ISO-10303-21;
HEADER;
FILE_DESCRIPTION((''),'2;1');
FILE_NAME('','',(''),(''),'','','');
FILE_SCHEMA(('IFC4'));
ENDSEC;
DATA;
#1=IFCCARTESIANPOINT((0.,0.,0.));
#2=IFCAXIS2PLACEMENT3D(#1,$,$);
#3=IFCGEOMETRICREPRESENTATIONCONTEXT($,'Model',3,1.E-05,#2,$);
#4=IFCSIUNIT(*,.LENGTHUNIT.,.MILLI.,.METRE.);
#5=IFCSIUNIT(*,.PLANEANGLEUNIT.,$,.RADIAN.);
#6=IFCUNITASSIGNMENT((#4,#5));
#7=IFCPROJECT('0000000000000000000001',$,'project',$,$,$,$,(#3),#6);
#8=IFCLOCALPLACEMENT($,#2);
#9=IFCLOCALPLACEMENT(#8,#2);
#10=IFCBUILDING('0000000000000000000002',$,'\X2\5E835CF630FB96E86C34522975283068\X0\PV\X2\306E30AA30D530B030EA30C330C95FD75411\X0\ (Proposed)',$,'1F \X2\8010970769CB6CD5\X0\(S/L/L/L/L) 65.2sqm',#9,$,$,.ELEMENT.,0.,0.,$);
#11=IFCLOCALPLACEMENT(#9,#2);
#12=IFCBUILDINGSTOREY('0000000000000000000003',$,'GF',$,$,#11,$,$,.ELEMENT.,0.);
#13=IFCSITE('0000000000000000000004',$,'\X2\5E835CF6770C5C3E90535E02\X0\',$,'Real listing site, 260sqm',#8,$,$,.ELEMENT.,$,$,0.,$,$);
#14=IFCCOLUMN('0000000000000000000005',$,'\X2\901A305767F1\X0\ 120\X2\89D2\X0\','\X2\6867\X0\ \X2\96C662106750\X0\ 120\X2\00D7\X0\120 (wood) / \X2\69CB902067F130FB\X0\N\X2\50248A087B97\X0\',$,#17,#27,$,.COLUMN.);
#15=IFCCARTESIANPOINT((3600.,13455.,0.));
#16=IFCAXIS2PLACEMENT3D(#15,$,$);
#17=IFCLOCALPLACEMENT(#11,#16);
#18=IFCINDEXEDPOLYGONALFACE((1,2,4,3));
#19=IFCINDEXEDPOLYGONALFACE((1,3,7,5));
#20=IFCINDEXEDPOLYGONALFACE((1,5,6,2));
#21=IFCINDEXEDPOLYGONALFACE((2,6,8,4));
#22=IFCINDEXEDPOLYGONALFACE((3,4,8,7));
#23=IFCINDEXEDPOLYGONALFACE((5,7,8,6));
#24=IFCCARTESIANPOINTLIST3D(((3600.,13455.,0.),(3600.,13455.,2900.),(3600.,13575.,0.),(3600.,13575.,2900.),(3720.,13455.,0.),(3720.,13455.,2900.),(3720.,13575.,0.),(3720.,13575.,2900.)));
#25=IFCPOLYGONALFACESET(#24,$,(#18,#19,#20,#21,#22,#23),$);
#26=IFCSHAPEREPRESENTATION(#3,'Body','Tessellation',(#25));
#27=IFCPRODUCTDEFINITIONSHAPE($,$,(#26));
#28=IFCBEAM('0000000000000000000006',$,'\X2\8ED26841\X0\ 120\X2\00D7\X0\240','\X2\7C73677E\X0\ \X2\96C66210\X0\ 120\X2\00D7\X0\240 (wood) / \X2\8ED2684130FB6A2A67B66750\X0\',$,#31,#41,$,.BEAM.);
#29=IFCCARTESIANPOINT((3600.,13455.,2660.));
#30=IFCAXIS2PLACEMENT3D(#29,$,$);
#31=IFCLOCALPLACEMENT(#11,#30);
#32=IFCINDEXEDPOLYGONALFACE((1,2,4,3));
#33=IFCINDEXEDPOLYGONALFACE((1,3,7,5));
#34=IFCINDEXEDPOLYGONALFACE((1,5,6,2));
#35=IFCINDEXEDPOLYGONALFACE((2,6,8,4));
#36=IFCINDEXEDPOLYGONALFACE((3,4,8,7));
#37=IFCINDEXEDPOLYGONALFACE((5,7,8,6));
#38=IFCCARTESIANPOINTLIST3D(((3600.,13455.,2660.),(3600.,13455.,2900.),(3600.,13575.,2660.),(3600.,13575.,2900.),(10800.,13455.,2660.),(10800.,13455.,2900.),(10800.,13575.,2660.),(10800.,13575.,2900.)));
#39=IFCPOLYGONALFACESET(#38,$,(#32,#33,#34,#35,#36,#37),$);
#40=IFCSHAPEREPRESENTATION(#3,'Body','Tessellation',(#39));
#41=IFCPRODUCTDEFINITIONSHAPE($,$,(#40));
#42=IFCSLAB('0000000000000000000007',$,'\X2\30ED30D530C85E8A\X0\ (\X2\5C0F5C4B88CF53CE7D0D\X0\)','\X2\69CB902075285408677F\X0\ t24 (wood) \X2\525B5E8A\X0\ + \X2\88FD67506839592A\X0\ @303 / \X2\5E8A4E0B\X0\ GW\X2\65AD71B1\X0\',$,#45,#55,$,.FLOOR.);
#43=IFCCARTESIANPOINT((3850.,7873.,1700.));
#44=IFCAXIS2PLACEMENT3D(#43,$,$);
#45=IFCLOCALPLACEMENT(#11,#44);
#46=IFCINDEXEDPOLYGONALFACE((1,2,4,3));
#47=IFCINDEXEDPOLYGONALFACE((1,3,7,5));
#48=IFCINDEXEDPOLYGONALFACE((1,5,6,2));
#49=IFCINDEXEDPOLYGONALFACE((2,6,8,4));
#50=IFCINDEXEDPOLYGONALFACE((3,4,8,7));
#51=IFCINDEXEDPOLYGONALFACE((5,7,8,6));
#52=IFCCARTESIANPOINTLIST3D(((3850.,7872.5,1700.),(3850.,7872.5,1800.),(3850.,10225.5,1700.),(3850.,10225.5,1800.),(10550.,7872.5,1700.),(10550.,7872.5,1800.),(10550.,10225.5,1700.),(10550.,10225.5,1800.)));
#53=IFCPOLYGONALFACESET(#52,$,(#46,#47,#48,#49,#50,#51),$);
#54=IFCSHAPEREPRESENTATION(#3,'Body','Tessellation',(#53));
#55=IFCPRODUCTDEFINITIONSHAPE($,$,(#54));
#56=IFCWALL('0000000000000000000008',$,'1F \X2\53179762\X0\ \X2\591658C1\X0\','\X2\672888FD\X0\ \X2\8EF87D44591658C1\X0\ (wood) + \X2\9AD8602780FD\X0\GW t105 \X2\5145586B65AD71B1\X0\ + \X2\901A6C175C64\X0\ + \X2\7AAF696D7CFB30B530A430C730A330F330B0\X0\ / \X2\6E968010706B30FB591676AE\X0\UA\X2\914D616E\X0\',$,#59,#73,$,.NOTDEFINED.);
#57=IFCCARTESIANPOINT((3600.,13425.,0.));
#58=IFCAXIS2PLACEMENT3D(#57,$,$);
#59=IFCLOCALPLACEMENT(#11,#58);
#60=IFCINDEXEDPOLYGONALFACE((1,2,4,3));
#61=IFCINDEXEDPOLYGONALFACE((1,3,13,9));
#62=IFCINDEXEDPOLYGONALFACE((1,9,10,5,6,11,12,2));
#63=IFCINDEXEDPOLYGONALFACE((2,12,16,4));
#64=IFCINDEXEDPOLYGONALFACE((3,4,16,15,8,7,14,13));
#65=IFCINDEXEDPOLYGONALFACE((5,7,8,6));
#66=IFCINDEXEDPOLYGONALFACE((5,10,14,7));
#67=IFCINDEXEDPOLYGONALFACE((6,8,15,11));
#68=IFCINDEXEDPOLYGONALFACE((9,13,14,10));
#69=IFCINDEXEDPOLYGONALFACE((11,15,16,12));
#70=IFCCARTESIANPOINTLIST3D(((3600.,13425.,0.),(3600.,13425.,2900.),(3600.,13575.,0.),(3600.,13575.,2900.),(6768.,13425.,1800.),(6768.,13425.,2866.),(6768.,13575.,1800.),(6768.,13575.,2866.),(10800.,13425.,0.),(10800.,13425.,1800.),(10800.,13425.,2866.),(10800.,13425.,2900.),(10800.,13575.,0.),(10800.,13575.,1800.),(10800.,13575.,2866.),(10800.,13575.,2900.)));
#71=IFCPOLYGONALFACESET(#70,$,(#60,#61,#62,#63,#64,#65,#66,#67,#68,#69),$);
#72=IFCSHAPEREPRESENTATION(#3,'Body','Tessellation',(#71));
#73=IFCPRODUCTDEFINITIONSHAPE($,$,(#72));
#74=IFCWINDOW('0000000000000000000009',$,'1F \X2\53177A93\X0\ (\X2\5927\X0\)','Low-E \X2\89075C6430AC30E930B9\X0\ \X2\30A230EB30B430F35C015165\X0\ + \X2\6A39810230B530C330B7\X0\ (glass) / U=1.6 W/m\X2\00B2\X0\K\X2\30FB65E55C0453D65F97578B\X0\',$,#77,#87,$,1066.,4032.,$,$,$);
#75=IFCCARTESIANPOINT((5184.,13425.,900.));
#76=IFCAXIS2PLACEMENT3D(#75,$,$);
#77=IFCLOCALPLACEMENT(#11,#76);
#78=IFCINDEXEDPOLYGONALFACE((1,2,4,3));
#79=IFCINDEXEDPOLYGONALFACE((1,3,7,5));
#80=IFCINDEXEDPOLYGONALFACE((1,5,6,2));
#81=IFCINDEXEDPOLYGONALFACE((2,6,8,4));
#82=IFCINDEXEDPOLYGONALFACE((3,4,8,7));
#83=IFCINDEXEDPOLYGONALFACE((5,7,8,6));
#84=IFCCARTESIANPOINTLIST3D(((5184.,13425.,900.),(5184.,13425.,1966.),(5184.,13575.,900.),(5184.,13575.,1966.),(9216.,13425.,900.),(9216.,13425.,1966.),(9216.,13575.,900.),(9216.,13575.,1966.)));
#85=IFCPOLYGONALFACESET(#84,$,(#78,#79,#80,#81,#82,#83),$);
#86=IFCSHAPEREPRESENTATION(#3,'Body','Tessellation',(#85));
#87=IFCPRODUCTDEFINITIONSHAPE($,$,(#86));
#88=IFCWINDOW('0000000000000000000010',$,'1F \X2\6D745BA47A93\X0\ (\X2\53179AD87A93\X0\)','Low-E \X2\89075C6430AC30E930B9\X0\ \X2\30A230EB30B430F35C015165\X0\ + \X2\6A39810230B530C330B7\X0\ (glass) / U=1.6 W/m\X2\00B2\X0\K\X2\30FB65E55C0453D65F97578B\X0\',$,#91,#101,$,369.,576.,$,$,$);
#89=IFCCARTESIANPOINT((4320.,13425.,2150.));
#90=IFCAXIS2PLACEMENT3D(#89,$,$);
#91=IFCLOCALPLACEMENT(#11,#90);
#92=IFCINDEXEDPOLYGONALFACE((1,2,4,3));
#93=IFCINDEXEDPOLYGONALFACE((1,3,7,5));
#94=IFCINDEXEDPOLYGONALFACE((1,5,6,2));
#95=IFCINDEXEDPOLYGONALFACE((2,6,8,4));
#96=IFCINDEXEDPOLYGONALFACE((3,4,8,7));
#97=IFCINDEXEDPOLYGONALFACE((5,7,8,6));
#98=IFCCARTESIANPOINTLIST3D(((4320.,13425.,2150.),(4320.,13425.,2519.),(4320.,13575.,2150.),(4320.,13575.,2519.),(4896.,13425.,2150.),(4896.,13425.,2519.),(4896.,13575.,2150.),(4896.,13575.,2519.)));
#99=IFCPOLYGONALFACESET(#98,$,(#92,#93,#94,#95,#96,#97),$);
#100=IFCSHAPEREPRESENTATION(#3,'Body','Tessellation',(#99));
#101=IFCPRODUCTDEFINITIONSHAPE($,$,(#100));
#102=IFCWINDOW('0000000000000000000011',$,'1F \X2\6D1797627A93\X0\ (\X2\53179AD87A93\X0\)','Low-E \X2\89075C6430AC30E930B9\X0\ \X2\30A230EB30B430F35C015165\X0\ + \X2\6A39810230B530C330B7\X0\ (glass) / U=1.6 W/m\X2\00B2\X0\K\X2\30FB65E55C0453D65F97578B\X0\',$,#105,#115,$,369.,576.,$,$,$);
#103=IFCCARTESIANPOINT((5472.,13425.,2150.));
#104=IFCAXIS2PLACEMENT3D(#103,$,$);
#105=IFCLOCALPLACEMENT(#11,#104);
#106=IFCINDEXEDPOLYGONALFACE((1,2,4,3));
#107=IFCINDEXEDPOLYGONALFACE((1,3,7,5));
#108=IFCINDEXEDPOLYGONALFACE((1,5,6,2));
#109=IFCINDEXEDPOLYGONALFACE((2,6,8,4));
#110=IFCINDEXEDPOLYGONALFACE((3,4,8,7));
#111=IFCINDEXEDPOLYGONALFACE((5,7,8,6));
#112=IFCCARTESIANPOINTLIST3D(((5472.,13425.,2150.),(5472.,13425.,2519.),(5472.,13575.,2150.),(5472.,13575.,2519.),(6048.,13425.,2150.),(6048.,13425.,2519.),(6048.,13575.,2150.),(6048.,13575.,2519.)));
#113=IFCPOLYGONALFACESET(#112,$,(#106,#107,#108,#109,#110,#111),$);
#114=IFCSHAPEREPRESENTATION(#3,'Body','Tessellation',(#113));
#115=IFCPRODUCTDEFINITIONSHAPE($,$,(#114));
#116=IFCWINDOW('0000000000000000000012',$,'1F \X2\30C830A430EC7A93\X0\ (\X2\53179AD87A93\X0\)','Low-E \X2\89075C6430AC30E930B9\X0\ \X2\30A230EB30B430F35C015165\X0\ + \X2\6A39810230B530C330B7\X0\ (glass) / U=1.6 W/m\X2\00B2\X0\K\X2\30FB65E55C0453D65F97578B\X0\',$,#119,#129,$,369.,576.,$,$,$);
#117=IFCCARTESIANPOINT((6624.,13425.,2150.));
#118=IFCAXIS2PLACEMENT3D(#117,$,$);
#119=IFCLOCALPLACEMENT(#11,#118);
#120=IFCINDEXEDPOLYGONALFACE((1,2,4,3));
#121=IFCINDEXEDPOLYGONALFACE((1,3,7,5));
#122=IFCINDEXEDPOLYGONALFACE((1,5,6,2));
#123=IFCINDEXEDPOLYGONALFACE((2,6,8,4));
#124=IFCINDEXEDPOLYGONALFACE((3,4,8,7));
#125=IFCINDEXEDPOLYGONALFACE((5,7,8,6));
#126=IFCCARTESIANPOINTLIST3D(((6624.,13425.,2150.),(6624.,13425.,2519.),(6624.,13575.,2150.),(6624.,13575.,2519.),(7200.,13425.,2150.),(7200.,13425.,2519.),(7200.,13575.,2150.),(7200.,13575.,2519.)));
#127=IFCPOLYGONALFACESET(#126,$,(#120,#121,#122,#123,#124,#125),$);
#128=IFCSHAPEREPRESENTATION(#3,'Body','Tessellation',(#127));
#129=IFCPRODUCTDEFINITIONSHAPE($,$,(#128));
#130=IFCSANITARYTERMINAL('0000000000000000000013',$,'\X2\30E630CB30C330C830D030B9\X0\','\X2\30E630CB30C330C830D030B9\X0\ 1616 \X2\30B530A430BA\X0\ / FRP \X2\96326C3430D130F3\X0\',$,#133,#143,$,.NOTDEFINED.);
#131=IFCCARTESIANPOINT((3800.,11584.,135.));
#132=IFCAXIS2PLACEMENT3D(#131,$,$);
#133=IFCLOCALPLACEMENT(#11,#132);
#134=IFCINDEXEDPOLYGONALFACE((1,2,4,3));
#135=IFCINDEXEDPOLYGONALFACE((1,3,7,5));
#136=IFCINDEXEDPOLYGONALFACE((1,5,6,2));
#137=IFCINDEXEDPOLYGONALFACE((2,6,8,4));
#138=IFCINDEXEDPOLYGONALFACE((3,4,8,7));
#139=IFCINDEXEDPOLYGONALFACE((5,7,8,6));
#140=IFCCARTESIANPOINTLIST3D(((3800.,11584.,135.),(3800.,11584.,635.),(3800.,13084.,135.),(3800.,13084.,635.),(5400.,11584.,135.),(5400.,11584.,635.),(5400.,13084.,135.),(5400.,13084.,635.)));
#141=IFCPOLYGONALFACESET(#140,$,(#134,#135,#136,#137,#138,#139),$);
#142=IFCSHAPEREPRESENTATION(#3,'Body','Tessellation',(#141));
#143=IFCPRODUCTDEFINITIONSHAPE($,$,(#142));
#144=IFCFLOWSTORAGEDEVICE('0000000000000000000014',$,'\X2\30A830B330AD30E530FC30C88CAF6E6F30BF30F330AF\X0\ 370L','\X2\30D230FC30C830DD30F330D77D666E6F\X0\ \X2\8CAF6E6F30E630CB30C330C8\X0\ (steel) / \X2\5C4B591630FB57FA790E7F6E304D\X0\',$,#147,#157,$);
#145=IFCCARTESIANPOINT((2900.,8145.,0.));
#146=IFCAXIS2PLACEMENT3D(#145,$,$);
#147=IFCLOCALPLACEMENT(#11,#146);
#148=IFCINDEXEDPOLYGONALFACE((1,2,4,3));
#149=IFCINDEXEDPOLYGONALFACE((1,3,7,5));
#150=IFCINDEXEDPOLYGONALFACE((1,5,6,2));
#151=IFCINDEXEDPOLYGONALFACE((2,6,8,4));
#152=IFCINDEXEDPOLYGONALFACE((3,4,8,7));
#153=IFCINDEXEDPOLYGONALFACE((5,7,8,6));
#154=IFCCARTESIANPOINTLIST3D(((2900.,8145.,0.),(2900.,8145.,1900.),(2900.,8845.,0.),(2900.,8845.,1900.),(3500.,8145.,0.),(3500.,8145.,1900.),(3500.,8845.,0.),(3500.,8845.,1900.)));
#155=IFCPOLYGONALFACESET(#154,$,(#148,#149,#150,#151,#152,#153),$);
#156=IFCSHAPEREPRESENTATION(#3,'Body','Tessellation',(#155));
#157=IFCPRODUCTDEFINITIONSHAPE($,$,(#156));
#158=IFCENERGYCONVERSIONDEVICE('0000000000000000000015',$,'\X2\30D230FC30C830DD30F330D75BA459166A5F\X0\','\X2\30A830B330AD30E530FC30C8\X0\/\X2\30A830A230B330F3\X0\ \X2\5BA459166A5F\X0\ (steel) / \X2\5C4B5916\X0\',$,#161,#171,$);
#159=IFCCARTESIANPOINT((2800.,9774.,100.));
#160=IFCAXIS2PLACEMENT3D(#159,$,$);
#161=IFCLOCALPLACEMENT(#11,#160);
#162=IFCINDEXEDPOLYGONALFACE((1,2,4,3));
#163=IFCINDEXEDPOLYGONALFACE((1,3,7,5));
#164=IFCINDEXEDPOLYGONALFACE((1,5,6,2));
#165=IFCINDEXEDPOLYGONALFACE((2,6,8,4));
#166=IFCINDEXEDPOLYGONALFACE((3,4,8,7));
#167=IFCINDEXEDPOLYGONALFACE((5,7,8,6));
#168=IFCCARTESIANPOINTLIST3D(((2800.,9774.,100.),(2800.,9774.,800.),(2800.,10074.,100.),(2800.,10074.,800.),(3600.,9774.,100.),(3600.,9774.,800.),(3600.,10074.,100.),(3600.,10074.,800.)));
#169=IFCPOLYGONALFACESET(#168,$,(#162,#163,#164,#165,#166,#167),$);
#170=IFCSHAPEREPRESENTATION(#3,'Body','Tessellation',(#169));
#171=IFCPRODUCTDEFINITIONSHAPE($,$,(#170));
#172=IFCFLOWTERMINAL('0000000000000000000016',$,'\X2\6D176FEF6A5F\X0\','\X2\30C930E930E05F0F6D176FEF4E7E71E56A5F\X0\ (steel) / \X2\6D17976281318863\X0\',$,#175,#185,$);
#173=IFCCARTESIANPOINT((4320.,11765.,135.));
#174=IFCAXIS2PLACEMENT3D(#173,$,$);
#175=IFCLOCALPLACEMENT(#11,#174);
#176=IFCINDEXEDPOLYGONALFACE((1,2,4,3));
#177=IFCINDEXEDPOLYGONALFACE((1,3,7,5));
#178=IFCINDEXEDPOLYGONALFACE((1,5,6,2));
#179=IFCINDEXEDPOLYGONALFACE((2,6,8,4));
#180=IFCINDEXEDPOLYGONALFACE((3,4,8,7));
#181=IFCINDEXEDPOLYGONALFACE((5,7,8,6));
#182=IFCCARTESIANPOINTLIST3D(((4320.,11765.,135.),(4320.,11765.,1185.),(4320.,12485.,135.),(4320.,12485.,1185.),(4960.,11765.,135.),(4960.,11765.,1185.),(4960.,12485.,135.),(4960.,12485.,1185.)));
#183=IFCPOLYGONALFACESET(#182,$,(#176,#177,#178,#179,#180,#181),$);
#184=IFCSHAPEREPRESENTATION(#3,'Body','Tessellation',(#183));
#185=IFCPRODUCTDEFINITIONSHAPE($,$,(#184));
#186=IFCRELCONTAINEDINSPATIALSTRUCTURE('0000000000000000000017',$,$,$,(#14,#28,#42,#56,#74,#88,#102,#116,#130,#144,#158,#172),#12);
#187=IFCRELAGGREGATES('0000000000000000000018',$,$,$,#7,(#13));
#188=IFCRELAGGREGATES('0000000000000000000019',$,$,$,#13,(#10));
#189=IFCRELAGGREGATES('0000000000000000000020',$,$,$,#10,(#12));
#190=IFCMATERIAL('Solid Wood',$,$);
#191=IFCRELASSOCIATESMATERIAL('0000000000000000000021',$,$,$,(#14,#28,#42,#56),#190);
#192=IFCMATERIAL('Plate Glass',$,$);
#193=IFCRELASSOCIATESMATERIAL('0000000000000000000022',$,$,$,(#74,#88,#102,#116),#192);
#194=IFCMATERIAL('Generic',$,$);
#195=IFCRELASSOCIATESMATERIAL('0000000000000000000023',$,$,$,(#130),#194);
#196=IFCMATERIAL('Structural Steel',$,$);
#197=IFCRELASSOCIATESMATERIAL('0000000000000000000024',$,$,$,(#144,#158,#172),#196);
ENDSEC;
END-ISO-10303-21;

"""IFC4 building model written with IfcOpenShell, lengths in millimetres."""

from ifc_helpers import new_model, si_unit, frame, frame_2d, origin, place, context, project, spatial, rectangle, extrude, material, element, fill, save


model = new_model("IFC4")

# Units and contexts
model_context = context("Model", 3, precision=1e-05, world=origin())
ifc_project = project(units=[si_unit("LENGTHUNIT", "METRE", prefix="MILLI"), si_unit("PLANEANGLEUNIT", "RADIAN")], contexts=[model_context])

# Site, building, storey
site_placement = place(None, origin())
site = spatial("IfcSite", under=ifc_project, at=site_placement, Name="広島県尾道市", ObjectType="Real listing site, 260sqm", CompositionType="ELEMENT", RefElevation=0.0)
building_placement = place(site_placement, origin())
building = spatial("IfcBuilding", under=site, at=building_placement, Name="広島・雨水利用とPVのオフグリッド志向 (Proposed)", ObjectType="1F 耐震構法(S/L/L/L/L) 65.2sqm", CompositionType="ELEMENT", ElevationOfRefHeight=0.0, ElevationOfTerrain=0.0)
storey_placement = place(building_placement, origin())
storey = spatial("IfcBuildingStorey", under=building, at=storey_placement, Name="GF", CompositionType="ELEMENT", Elevation=0.0)

# Column
ifc_material_1 = material(Name="Solid Wood")
column_1_placement = place(storey_placement, frame((3600.0, 13455.0, 0.0)))
element("IfcColumn", 1, at=column_1_placement, inside=storey, material=ifc_material_1, Name="通し柱 120角", Description="桧 集成材 120×120 (wood) / 構造柱・N値計算", PredefinedType="COLUMN", context=model_context, shape_type="SweptSolid", body=[
    extrude(rectangle(XDim=120.0, YDim=120.0, at=frame_2d((60.0, 60.0))), frame((3600.0, 13455.0, 0.0)), (0.0, 0.0, 1.0), 2900.0),
])

# Beam
beam_1_placement = place(storey_placement, frame((3600.0, 13455.0, 2660.0)))
element("IfcBeam", 2, at=beam_1_placement, inside=storey, material=ifc_material_1, Name="軒桁 120×240", Description="米松 集成 120×240 (wood) / 軒桁・横架材", PredefinedType="BEAM", context=model_context, shape_type="SweptSolid", body=[
    extrude(rectangle(XDim=7200.0, YDim=120.0, at=frame_2d((3600.0, 60.0))), frame((3600.0, 13455.0, 2660.0)), (0.0, 0.0, 1.0), 240.0),
])

# Slab
slab_placement = place(storey_placement, frame((3850.0, 7873.0, 1700.0)))
element("IfcSlab", 3, at=slab_placement, inside=storey, material=ifc_material_1, Name="ロフト床 (小屋裏収納)", Description="構造用合板 t24 (wood) 剛床 + 製材根太 @303 / 床下 GW断熱", PredefinedType="FLOOR", context=model_context, shape_type="SweptSolid", body=[
    extrude(rectangle(XDim=6700.0, YDim=2353.0, at=frame_2d((3350.0, 1176.0))), frame((3850.0, 7873.0, 1700.0)), (0.0, 0.0, 1.0), 100.0),
])

# Wall, openings, windows
wall_1_placement = place(storey_placement, frame((3600.0, 13425.0, 0.0)))
wall_1 = element("IfcWall", 4, at=wall_1_placement, inside=storey, material=ifc_material_1, Name="1F 北面 外壁", Description="木製 軸組外壁 (wood) + 高性能GW t105 充填断熱 + 通気層 + 窯業系サイディング / 準耐火・外皮UA配慮", PredefinedType="NOTDEFINED", context=model_context, shape_type="SweptSolid", body=[
    extrude(rectangle(XDim=7200.0, YDim=150.0, at=frame_2d((3600.0, 75.0))), frame((3600.0, 13425.0, 0.0)), (0.0, 0.0, 1.0), 2900.0),
])
opening_1_placement = place(storey_placement, frame((5184.0, 13425.0, 900.0)))
opening_1 = element("IfcOpeningElement", 5, at=opening_1_placement, cuts=wall_1, PredefinedType="NOTDEFINED", context=model_context, shape_type="SweptSolid", body=[
    extrude(rectangle(XDim=4032.0, YDim=150.0, at=frame_2d((2016.0, 75.0))), frame((5184.0, 13425.0, 900.0)), (0.0, 0.0, 1.0), 1066.0),
])
opening_2_placement = place(storey_placement, frame((4320.0, 13425.0, 2150.0)))
opening_2 = element("IfcOpeningElement", 6, at=opening_2_placement, cuts=wall_1, PredefinedType="NOTDEFINED", context=model_context, shape_type="SweptSolid", body=[
    extrude(rectangle(XDim=576.0, YDim=150.0, at=frame_2d((288.0, 75.0))), frame((4320.0, 13425.0, 2150.0)), (0.0, 0.0, 1.0), 369.0),
])
opening_3_placement = place(storey_placement, frame((5472.0, 13425.0, 2150.0)))
opening_3 = element("IfcOpeningElement", 7, at=opening_3_placement, cuts=wall_1, PredefinedType="NOTDEFINED", context=model_context, shape_type="SweptSolid", body=[
    extrude(rectangle(XDim=576.0, YDim=150.0, at=frame_2d((288.0, 75.0))), frame((5472.0, 13425.0, 2150.0)), (0.0, 0.0, 1.0), 369.0),
])
opening_4_placement = place(storey_placement, frame((6624.0, 13425.0, 2150.0)))
opening_4 = element("IfcOpeningElement", 8, at=opening_4_placement, cuts=wall_1, PredefinedType="NOTDEFINED", context=model_context, shape_type="SweptSolid", body=[
    extrude(rectangle(XDim=576.0, YDim=150.0, at=frame_2d((288.0, 75.0))), frame((6624.0, 13425.0, 2150.0)), (0.0, 0.0, 1.0), 369.0),
])
ifc_material_2 = material(Name="Plate Glass")
window_1_placement = place(storey_placement, frame((5184.0, 13425.0, 900.0)))
window_1 = element("IfcWindow", 9, at=window_1_placement, inside=storey, material=ifc_material_2, Name="1F 北窓 (大)", Description="Low-E 複層ガラス アルゴン封入 + 樹脂サッシ (glass) / U=1.6 W/m²K・日射取得型", OverallHeight=1066.0, OverallWidth=4032.0, context=model_context, shape_type="SweptSolid", body=[
    extrude(rectangle(XDim=4032.0, YDim=150.0, at=frame_2d((2016.0, 75.0))), frame((5184.0, 13425.0, 900.0)), (0.0, 0.0, 1.0), 1066.0),
])
fill(opening_1, window_1)
window_2_placement = place(storey_placement, frame((4320.0, 13425.0, 2150.0)))
window_2 = element("IfcWindow", 10, at=window_2_placement, inside=storey, material=ifc_material_2, Name="1F 浴室窓 (北高窓)", Description="Low-E 複層ガラス アルゴン封入 + 樹脂サッシ (glass) / U=1.6 W/m²K・日射取得型", OverallHeight=369.0, OverallWidth=576.0, context=model_context, shape_type="SweptSolid", body=[
    extrude(rectangle(XDim=576.0, YDim=150.0, at=frame_2d((288.0, 75.0))), frame((4320.0, 13425.0, 2150.0)), (0.0, 0.0, 1.0), 369.0),
])
fill(opening_2, window_2)
window_3_placement = place(storey_placement, frame((5472.0, 13425.0, 2150.0)))
window_3 = element("IfcWindow", 11, at=window_3_placement, inside=storey, material=ifc_material_2, Name="1F 洗面窓 (北高窓)", Description="Low-E 複層ガラス アルゴン封入 + 樹脂サッシ (glass) / U=1.6 W/m²K・日射取得型", OverallHeight=369.0, OverallWidth=576.0, context=model_context, shape_type="SweptSolid", body=[
    extrude(rectangle(XDim=576.0, YDim=150.0, at=frame_2d((288.0, 75.0))), frame((5472.0, 13425.0, 2150.0)), (0.0, 0.0, 1.0), 369.0),
])
fill(opening_3, window_3)
window_4_placement = place(storey_placement, frame((6624.0, 13425.0, 2150.0)))
window_4 = element("IfcWindow", 12, at=window_4_placement, inside=storey, material=ifc_material_2, Name="1F トイレ窓 (北高窓)", Description="Low-E 複層ガラス アルゴン封入 + 樹脂サッシ (glass) / U=1.6 W/m²K・日射取得型", OverallHeight=369.0, OverallWidth=576.0, context=model_context, shape_type="SweptSolid", body=[
    extrude(rectangle(XDim=576.0, YDim=150.0, at=frame_2d((288.0, 75.0))), frame((6624.0, 13425.0, 2150.0)), (0.0, 0.0, 1.0), 369.0),
])
fill(opening_4, window_4)

# Sanitary terminal
ifc_material_3 = material(Name="Generic")
sanitary_terminal_placement = place(storey_placement, frame((3800.0, 11584.0, 135.0)))
element("IfcSanitaryTerminal", 13, at=sanitary_terminal_placement, inside=storey, material=ifc_material_3, Name="ユニットバス", Description="ユニットバス 1616 サイズ / FRP 防水パン", PredefinedType="NOTDEFINED", context=model_context, shape_type="SweptSolid", body=[
    extrude(rectangle(XDim=1600.0, YDim=1500.0, at=frame_2d((800.0, 750.0))), frame((3800.0, 11584.0, 135.0)), (0.0, 0.0, 1.0), 500.0),
])

# Flow storage device
ifc_material_4 = material(Name="Structural Steel")
flow_storage_device_placement = place(storey_placement, frame((2900.0, 8145.0, 0.0)))
element("IfcFlowStorageDevice", 14, at=flow_storage_device_placement, inside=storey, material=ifc_material_4, Name="エコキュート貯湯タンク 370L", Description="ヒートポンプ給湯 貯湯ユニット (steel) / 屋外・基礎置き", context=model_context, shape_type="SweptSolid", body=[
    extrude(rectangle(XDim=600.0, YDim=700.0, at=frame_2d((300.0, 350.0))), frame((2900.0, 8145.0, 0.0)), (0.0, 0.0, 1.0), 1900.0),
])

# Energy conversion device
energy_conversion_device_placement = place(storey_placement, frame((2800.0, 9774.0, 100.0)))
element("IfcEnergyConversionDevice", 15, at=energy_conversion_device_placement, inside=storey, material=ifc_material_4, Name="ヒートポンプ室外機", Description="エコキュート/エアコン 室外機 (steel) / 屋外", context=model_context, shape_type="SweptSolid", body=[
    extrude(rectangle(XDim=800.0, YDim=300.0, at=frame_2d((400.0, 150.0))), frame((2800.0, 9774.0, 100.0)), (0.0, 0.0, 1.0), 700.0),
])

# Flow terminal
flow_terminal_placement = place(storey_placement, frame((4320.0, 11765.0, 135.0)))
element("IfcFlowTerminal", 16, at=flow_terminal_placement, inside=storey, material=ifc_material_4, Name="洗濯機", Description="ドラム式洗濯乾燥機 (steel) / 洗面脱衣", context=model_context, shape_type="SweptSolid", body=[
    extrude(rectangle(XDim=640.0, YDim=720.0, at=frame_2d((320.0, 360.0))), frame((4320.0, 11765.0, 135.0)), (0.0, 0.0, 1.0), 1050.0),
])

save(model, "model.ifc")
